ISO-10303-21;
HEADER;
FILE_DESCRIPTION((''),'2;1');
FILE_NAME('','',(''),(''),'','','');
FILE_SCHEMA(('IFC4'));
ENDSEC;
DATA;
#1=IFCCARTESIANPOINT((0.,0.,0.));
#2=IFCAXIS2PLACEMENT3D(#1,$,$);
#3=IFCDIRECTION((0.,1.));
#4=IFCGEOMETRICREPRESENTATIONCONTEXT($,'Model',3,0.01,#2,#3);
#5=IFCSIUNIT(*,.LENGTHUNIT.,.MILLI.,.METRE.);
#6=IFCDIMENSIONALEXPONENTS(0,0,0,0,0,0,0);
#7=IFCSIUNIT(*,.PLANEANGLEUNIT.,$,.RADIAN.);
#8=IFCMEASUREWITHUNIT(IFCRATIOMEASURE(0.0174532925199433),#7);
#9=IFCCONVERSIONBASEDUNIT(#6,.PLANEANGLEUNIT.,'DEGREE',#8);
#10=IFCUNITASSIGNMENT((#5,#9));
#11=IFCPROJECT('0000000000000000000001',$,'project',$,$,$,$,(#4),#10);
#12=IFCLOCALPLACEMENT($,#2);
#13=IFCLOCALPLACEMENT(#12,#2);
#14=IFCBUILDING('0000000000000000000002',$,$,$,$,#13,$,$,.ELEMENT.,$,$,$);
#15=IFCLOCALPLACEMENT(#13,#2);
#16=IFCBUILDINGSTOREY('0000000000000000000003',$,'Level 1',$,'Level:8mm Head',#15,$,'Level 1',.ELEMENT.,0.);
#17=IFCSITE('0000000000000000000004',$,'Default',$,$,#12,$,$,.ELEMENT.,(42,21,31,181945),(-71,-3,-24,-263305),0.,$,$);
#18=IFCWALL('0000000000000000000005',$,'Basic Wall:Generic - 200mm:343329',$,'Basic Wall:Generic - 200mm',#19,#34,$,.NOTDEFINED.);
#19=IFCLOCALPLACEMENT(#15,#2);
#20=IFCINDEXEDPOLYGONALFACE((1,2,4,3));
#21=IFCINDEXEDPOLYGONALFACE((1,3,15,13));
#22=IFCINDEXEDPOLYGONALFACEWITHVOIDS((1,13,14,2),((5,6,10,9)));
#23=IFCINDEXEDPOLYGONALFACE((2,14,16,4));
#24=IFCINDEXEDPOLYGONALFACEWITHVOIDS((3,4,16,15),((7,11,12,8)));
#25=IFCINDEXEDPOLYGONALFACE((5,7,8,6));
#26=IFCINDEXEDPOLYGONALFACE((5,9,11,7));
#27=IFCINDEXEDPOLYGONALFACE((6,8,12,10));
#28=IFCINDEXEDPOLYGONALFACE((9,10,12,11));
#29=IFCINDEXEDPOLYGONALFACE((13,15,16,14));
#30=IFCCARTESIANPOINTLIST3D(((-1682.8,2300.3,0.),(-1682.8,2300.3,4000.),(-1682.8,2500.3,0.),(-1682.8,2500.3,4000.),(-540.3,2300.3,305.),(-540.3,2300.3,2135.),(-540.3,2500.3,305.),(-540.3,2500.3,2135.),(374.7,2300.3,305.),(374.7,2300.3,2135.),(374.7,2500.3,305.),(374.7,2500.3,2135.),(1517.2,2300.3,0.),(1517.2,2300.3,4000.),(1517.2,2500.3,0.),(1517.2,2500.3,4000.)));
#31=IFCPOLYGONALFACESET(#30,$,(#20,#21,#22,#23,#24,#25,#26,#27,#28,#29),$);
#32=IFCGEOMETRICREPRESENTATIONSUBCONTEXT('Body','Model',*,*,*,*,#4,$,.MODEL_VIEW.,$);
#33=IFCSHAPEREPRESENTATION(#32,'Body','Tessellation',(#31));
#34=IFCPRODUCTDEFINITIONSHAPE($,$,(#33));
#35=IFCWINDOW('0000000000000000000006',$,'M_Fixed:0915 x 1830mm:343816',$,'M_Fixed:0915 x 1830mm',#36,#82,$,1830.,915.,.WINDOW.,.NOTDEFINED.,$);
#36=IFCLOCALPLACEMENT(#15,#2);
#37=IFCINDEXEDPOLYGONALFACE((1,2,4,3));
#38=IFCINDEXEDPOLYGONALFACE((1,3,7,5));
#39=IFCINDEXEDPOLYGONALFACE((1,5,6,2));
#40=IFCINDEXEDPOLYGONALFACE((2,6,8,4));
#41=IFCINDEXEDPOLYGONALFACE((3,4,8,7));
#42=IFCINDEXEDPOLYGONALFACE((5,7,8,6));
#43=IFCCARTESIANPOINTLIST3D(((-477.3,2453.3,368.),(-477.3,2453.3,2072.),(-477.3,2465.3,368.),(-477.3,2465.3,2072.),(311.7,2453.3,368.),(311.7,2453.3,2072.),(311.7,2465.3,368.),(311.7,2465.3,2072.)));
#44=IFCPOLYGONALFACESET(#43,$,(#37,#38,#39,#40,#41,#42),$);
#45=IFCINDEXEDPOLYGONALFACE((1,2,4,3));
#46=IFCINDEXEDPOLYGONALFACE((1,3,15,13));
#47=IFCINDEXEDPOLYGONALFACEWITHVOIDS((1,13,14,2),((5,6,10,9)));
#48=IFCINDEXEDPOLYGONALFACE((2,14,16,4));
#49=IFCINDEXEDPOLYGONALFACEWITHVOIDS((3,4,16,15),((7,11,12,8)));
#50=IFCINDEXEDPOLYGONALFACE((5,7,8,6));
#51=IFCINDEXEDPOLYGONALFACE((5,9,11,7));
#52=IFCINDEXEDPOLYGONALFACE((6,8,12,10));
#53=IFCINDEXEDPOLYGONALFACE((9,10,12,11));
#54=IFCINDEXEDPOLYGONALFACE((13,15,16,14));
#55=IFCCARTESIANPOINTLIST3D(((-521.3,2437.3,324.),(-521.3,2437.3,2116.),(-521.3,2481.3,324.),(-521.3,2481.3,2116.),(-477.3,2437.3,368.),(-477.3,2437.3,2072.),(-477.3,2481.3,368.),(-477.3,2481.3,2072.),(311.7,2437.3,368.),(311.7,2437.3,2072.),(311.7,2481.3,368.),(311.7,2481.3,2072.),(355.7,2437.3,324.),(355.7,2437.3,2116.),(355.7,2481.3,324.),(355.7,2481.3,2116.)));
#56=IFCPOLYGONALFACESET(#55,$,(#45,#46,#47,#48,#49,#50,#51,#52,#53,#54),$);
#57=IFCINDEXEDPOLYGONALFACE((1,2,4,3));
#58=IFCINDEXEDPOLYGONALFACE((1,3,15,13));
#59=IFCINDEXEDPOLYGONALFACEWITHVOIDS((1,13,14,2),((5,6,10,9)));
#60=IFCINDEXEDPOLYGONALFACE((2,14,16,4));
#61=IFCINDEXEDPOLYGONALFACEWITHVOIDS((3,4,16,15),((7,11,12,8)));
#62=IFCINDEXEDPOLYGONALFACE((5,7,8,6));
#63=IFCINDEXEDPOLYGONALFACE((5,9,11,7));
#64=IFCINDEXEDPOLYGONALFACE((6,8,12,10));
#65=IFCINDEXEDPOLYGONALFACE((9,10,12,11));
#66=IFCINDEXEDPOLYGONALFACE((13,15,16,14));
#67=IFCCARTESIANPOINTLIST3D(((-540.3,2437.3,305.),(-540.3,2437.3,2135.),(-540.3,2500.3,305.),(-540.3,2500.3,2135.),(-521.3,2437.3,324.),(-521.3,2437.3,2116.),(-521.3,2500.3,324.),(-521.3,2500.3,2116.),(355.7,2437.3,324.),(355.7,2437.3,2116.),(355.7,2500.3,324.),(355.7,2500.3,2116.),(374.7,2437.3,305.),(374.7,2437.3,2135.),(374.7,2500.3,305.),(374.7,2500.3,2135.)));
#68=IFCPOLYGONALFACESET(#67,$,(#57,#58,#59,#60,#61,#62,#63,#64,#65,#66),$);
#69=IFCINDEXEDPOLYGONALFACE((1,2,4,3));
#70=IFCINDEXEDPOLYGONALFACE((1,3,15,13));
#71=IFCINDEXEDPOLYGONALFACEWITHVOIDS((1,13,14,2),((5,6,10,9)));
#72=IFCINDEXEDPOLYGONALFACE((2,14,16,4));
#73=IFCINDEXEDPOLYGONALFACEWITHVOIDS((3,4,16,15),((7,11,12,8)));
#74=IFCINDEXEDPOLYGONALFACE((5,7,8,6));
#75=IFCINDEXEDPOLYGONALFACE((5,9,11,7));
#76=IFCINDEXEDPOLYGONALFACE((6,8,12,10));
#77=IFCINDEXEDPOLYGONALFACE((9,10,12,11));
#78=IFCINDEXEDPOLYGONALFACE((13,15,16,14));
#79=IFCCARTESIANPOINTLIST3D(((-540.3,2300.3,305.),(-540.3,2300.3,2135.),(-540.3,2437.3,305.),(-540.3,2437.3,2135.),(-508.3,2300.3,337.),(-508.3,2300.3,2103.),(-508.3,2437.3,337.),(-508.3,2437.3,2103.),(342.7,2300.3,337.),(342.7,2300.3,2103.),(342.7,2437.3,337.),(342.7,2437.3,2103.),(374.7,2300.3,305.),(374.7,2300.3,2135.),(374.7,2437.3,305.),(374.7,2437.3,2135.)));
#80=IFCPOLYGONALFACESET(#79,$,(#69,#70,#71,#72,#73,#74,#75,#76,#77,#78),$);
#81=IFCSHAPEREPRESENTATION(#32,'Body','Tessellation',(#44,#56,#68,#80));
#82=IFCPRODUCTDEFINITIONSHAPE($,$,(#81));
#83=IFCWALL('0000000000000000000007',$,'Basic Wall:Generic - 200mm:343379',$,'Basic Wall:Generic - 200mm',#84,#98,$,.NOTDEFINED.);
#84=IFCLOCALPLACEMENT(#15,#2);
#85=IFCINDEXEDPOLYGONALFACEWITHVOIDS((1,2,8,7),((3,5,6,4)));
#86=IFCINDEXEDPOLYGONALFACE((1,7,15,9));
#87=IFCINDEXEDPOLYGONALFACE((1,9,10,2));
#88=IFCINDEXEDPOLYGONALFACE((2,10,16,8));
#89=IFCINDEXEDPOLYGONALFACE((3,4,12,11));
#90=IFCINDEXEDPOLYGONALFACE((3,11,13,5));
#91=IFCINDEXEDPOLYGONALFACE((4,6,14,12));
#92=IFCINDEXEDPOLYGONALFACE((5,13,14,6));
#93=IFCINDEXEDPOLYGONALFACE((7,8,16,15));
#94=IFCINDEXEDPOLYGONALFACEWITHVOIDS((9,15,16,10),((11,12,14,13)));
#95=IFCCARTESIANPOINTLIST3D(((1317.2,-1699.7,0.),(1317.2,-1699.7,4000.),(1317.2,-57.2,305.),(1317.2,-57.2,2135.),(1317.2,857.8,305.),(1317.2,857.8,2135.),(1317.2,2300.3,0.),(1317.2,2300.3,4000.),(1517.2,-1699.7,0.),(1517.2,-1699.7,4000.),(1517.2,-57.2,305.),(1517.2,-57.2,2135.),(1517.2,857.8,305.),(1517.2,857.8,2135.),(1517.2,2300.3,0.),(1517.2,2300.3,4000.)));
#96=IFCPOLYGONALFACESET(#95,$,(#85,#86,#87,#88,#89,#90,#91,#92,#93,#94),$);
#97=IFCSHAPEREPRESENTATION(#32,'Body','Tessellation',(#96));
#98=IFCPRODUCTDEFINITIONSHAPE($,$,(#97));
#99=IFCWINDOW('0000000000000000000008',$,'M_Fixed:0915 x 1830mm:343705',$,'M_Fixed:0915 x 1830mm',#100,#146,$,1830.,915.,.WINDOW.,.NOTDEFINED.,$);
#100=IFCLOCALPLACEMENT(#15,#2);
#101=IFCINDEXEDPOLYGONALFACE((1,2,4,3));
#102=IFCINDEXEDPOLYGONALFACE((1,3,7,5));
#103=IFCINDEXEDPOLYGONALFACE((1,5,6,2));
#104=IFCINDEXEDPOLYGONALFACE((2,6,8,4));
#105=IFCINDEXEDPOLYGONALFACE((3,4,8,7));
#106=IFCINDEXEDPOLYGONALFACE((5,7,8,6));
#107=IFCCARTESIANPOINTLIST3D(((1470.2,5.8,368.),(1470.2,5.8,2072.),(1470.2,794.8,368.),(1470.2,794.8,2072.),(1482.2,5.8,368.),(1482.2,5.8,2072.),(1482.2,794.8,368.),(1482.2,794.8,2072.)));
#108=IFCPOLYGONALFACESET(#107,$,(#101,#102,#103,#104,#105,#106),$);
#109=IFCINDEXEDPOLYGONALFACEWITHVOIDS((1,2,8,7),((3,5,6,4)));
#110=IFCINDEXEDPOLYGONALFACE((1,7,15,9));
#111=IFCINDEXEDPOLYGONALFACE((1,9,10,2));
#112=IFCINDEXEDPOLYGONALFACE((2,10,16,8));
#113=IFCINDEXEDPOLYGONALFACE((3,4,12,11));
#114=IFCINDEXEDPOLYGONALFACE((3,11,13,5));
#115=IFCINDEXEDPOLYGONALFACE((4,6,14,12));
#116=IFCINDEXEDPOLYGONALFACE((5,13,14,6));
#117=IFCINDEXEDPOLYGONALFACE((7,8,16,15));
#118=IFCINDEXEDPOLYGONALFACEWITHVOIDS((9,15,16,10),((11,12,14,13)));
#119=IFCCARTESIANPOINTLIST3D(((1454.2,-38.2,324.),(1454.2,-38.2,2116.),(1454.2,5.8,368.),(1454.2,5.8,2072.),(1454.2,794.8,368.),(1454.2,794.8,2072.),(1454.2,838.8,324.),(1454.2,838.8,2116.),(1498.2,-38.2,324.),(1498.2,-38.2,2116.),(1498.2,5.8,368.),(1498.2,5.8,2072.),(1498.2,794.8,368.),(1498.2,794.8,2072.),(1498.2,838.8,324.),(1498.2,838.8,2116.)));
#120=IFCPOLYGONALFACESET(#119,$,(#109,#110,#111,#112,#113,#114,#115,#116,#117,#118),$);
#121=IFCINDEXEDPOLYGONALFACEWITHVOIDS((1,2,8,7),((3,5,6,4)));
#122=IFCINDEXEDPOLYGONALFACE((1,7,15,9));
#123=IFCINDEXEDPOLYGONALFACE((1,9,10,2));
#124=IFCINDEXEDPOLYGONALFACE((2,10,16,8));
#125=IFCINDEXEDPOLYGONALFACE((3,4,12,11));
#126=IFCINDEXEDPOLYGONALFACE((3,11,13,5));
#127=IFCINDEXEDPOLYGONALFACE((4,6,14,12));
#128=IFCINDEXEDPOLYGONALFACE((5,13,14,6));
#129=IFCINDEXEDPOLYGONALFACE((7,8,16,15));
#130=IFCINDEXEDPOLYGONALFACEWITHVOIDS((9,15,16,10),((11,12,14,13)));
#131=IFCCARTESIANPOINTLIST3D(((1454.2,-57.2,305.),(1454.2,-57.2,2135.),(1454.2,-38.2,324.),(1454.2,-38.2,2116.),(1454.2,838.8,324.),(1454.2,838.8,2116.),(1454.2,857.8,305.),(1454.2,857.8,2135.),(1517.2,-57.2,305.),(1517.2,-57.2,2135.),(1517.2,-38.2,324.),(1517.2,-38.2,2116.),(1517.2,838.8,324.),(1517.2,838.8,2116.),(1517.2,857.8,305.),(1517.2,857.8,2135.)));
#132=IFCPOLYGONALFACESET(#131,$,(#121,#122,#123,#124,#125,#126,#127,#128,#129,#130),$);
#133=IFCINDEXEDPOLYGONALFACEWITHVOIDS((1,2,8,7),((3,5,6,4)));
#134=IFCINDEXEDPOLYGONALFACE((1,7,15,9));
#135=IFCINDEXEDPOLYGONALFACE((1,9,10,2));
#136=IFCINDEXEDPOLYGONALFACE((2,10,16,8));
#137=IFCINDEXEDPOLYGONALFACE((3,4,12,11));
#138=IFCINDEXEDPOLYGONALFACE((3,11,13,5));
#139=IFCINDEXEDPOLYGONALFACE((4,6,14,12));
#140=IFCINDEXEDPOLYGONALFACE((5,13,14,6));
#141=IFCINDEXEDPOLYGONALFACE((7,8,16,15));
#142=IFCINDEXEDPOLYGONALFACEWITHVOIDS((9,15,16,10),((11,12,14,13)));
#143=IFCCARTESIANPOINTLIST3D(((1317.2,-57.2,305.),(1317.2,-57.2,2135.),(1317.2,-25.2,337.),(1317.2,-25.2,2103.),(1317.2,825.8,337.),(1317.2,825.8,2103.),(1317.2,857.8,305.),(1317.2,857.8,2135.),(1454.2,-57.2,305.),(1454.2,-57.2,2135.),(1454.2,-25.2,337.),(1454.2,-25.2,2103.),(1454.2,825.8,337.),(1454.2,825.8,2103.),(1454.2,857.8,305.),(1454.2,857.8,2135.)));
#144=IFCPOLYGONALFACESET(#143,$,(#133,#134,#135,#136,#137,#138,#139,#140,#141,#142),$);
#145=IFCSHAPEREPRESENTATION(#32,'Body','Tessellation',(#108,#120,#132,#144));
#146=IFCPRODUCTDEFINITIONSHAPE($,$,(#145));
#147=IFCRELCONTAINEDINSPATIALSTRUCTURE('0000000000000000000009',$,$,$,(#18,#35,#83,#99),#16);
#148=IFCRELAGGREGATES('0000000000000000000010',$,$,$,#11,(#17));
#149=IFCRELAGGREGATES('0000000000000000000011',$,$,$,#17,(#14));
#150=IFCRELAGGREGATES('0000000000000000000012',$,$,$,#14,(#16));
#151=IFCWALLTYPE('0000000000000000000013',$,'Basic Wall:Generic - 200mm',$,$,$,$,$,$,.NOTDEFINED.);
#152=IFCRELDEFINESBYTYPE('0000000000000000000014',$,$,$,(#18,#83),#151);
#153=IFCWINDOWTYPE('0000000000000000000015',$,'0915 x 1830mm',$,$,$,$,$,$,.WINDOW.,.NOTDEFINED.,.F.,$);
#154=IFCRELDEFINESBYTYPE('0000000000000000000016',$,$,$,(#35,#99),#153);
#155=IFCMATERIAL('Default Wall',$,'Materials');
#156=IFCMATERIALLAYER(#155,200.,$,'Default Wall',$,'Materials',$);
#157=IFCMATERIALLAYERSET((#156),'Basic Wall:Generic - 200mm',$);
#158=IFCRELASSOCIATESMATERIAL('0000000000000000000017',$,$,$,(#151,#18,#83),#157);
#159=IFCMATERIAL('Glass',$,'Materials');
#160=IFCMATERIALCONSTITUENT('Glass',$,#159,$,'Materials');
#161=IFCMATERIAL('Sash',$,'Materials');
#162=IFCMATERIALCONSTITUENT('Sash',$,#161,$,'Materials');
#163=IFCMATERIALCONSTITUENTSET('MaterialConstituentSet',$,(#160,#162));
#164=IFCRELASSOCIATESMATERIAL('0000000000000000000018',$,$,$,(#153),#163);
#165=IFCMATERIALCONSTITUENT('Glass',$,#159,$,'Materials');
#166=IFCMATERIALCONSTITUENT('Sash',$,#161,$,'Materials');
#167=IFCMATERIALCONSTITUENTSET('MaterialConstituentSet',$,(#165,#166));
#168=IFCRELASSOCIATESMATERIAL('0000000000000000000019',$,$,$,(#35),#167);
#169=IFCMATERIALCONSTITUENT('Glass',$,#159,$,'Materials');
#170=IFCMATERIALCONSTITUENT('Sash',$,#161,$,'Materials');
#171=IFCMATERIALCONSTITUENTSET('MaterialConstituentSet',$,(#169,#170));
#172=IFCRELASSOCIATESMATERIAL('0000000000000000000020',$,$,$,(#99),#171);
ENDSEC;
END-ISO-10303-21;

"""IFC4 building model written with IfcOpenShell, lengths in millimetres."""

from ifc_helpers import new_model, entity, si_unit, converted_unit, direction, frame, frame_2d, origin, place, context, subcontext, project, spatial, polyline, rectangle, outline, extrude, source, transform, mapped, material, layer, layer_set, layer_usage, constituent, constituent_set, type_object, type_shapes, element, fill, save


model = new_model("IFC4")

# Units and contexts
model_context = context("Model", 3, precision=0.01, world=origin(), true_north=direction((0.0, 1.0)))
body_context = subcontext(model_context, "Body", "Model", "MODEL_VIEW")
ifc_project = project(units=[si_unit("LENGTHUNIT", "METRE", prefix="MILLI"), converted_unit("PLANEANGLEUNIT", "DEGREE", entity("IfcRatioMeasure", 0.0174532925199433), si_unit("PLANEANGLEUNIT", "RADIAN"), dimensions=[0, 0, 0, 0, 0, 0, 0])], contexts=[model_context])

# Site, building, storey
site_placement = place(None, origin())
site = spatial("IfcSite", under=ifc_project, at=site_placement, Name="Default", CompositionType="ELEMENT", RefLatitude=(42, 21, 31, 181945), RefLongitude=(-71, -3, -24, -263305), RefElevation=0.0)
building_placement = place(site_placement, origin())
building = spatial("IfcBuilding", under=site, at=building_placement, CompositionType="ELEMENT")
storey_placement = place(building_placement, origin())
storey = spatial("IfcBuildingStorey", under=building, at=storey_placement, Name="Level 1", ObjectType="Level:8mm Head", LongName="Level 1", CompositionType="ELEMENT", Elevation=0.0)

# Walls, openings, windows
ifc_material_1 = material(Name="Default Wall", Category="Materials")
ifc_layer_1 = layer(ifc_material_1, 200.0, Name="Default Wall", Category="Materials")
ifc_layer_set_1 = layer_set([ifc_layer_1], Name="Basic Wall:Generic - 200mm")
ifc_layer_usage_1 = layer_usage(ifc_layer_set_1, "AXIS2", "NEGATIVE", 100.0)
wall_type = type_object("IfcWallType", Name="Basic Wall:Generic - 200mm", PredefinedType="NOTDEFINED", material=ifc_layer_set_1)
wall_1_placement = place(storey_placement, frame((-1682.8, 2400.3, 0.0)))
wall_1 = element("IfcWall", 1, at=wall_1_placement, inside=storey, type_object=wall_type, material=ifc_layer_usage_1, Name="Basic Wall:Generic - 200mm:343329", ObjectType="Basic Wall:Generic - 200mm", PredefinedType="NOTDEFINED", context=body_context, shape_type="SweptSolid", body=[
    extrude(rectangle(XDim=3200.0, YDim=200.0, at=frame_2d((1600.0, 0.0), x_axis=(-1.0, 0.0))), origin(), (0.0, 0.0, 1.0), 4000.0),
])
opening_1_placement = place(wall_1_placement, frame((1142.5, -100.0, 305.0)))
opening_1 = element("IfcOpeningElement", 2, at=opening_1_placement, cuts=wall_1, ObjectType="Opening", PredefinedType="OPENING", context=body_context, shape_type="SweptSolid", body=[
    extrude(rectangle(XDim=1830.0, YDim=915.0, at=frame_2d((915.0, 457.5), x_axis=(1.0, 0.0))), frame((0.0, 0.0, 0.0), z_axis=(0.0, 1.0, 0.0), x_axis=(0.0, 0.0, 1.0)), (0.0, 0.0, 1.0), 200.0),
])
ifc_material_2 = material(Name="Glass", Category="Materials")
ifc_constituent_1 = constituent(ifc_material_2, Name="Glass", Category="Materials")
ifc_material_3 = material(Name="Sash", Category="Materials")
ifc_constituent_2 = constituent(ifc_material_3, Name="Sash", Category="Materials")
ifc_constituent_set_1 = constituent_set(constituents=[ifc_constituent_1, ifc_constituent_2], Name="MaterialConstituentSet")
ifc_constituent_3 = constituent(ifc_material_2, Name="Glass", Category="Materials")
ifc_constituent_4 = constituent(ifc_material_3, Name="Sash", Category="Materials")
ifc_constituent_set_2 = constituent_set(constituents=[ifc_constituent_3, ifc_constituent_4], Name="MaterialConstituentSet")
window_type = type_object("IfcWindowType", Name="0915 x 1830mm", ParameterTakesPrecedence=False, PartitioningType="NOTDEFINED", PredefinedType="WINDOW", material=ifc_constituent_set_2)
shared_shape_1 = source(origin(), body_context, "Body", "SweptSolid", [
    extrude(rectangle(XDim=12.0, YDim=789.0, at=frame_2d((0.0, 0.0), x_axis=(1.0, 0.0))), frame((457.5, 159.0, 63.0), z_axis=(0.0, 0.0, 1.0), x_axis=(0.0, -1.0, 0.0)), (0.0, 0.0, 1.0), 1704.0),
    extrude(outline(polyline([(-438.5, -896.0), (438.5, -896.0), (438.5, 896.0), (-438.5, 896.0), (-438.5, -896.0)]), holes=[polyline([(-394.5, -852.0), (-394.5, 852.0), (394.5, 852.0), (394.5, -852.0), (-394.5, -852.0)])]), frame((457.5, 137.0, 915.0), z_axis=(0.0, 1.0, 0.0), x_axis=(1.0, 0.0, 0.0)), (0.0, 0.0, 1.0), 44.0),
    extrude(outline(polyline([(-457.5, -915.0), (457.5, -915.0), (457.5, 915.0), (-457.5, 915.0), (-457.5, -915.0)]), holes=[polyline([(-438.5, -896.0), (-438.5, 896.0), (438.5, 896.0), (438.5, -896.0), (-438.5, -896.0)])]), frame((457.5, 137.0, 915.0), z_axis=(0.0, 1.0, 0.0), x_axis=(1.0, 0.0, 0.0)), (0.0, 0.0, 1.0), 63.0),
    extrude(outline(polyline([(-457.5, -915.0), (457.5, -915.0), (457.5, 915.0), (-457.5, 915.0), (-457.5, -915.0)]), holes=[polyline([(-425.5, -883.0), (-425.5, 883.0), (425.5, 883.0), (425.5, -883.0), (-425.5, -883.0)])]), frame((457.5, 0.0, 915.0), z_axis=(0.0, 1.0, 0.0), x_axis=(1.0, 0.0, 0.0)), (0.0, 0.0, 1.0), 137.0),
])
type_shapes(window_type, [shared_shape_1])
window_1_placement = place(opening_1_placement, origin())
window_1 = element("IfcWindow", 3, at=window_1_placement, inside=storey, type_object=window_type, material=ifc_constituent_set_1, Name="M_Fixed:0915 x 1830mm:343816", ObjectType="M_Fixed:0915 x 1830mm", OverallHeight=1830.0, OverallWidth=915.0, PartitioningType="NOTDEFINED", PredefinedType="WINDOW", context=body_context, shape_type="MappedRepresentation", body=[
    mapped(shared_shape_1, transform((0.0, 0.0, 0.0), scale=1.0)),
])
fill(opening_1, window_1)
ifc_layer_usage_2 = layer_usage(ifc_layer_set_1, "AXIS2", "NEGATIVE", 100.0)
wall_2_placement = place(storey_placement, frame((1417.2, 2300.3, 0.0), z_axis=(0.0, 0.0, 1.0), x_axis=(0.0, -1.0, 0.0)))
wall_2 = element("IfcWall", 4, at=wall_2_placement, inside=storey, type_object=wall_type, material=ifc_layer_usage_2, Name="Basic Wall:Generic - 200mm:343379", ObjectType="Basic Wall:Generic - 200mm", PredefinedType="NOTDEFINED", context=body_context, shape_type="SweptSolid", body=[
    extrude(rectangle(XDim=4000.0, YDim=200.0, at=frame_2d((2000.0, 0.0), x_axis=(-1.0, 0.0))), origin(), (0.0, 0.0, 1.0), 4000.0),
])
opening_2_placement = place(wall_2_placement, frame((1442.5, -100.0, 305.0)))
opening_2 = element("IfcOpeningElement", 5, at=opening_2_placement, cuts=wall_2, ObjectType="Opening", PredefinedType="OPENING", context=body_context, shape_type="SweptSolid", body=[
    extrude(rectangle(XDim=1830.0, YDim=915.0, at=frame_2d((915.0, 457.5), x_axis=(1.0, 0.0))), frame((0.0, 0.0, 0.0), z_axis=(0.0, 1.0, 0.0), x_axis=(0.0, 0.0, 1.0)), (0.0, 0.0, 1.0), 200.0),
])
ifc_constituent_5 = constituent(ifc_material_2, Name="Glass", Category="Materials")
ifc_constituent_6 = constituent(ifc_material_3, Name="Sash", Category="Materials")
ifc_constituent_set_3 = constituent_set(constituents=[ifc_constituent_5, ifc_constituent_6], Name="MaterialConstituentSet")
window_2_placement = place(opening_2_placement, origin())
window_2 = element("IfcWindow", 6, at=window_2_placement, inside=storey, type_object=window_type, material=ifc_constituent_set_3, Name="M_Fixed:0915 x 1830mm:343705", ObjectType="M_Fixed:0915 x 1830mm", OverallHeight=1830.0, OverallWidth=915.0, PartitioningType="NOTDEFINED", PredefinedType="WINDOW", context=body_context, shape_type="MappedRepresentation", body=[
    mapped(shared_shape_1, transform((0.0, 0.0, 0.0), scale=1.0)),
])
fill(opening_2, window_2)

save(model, "model.ifc")
